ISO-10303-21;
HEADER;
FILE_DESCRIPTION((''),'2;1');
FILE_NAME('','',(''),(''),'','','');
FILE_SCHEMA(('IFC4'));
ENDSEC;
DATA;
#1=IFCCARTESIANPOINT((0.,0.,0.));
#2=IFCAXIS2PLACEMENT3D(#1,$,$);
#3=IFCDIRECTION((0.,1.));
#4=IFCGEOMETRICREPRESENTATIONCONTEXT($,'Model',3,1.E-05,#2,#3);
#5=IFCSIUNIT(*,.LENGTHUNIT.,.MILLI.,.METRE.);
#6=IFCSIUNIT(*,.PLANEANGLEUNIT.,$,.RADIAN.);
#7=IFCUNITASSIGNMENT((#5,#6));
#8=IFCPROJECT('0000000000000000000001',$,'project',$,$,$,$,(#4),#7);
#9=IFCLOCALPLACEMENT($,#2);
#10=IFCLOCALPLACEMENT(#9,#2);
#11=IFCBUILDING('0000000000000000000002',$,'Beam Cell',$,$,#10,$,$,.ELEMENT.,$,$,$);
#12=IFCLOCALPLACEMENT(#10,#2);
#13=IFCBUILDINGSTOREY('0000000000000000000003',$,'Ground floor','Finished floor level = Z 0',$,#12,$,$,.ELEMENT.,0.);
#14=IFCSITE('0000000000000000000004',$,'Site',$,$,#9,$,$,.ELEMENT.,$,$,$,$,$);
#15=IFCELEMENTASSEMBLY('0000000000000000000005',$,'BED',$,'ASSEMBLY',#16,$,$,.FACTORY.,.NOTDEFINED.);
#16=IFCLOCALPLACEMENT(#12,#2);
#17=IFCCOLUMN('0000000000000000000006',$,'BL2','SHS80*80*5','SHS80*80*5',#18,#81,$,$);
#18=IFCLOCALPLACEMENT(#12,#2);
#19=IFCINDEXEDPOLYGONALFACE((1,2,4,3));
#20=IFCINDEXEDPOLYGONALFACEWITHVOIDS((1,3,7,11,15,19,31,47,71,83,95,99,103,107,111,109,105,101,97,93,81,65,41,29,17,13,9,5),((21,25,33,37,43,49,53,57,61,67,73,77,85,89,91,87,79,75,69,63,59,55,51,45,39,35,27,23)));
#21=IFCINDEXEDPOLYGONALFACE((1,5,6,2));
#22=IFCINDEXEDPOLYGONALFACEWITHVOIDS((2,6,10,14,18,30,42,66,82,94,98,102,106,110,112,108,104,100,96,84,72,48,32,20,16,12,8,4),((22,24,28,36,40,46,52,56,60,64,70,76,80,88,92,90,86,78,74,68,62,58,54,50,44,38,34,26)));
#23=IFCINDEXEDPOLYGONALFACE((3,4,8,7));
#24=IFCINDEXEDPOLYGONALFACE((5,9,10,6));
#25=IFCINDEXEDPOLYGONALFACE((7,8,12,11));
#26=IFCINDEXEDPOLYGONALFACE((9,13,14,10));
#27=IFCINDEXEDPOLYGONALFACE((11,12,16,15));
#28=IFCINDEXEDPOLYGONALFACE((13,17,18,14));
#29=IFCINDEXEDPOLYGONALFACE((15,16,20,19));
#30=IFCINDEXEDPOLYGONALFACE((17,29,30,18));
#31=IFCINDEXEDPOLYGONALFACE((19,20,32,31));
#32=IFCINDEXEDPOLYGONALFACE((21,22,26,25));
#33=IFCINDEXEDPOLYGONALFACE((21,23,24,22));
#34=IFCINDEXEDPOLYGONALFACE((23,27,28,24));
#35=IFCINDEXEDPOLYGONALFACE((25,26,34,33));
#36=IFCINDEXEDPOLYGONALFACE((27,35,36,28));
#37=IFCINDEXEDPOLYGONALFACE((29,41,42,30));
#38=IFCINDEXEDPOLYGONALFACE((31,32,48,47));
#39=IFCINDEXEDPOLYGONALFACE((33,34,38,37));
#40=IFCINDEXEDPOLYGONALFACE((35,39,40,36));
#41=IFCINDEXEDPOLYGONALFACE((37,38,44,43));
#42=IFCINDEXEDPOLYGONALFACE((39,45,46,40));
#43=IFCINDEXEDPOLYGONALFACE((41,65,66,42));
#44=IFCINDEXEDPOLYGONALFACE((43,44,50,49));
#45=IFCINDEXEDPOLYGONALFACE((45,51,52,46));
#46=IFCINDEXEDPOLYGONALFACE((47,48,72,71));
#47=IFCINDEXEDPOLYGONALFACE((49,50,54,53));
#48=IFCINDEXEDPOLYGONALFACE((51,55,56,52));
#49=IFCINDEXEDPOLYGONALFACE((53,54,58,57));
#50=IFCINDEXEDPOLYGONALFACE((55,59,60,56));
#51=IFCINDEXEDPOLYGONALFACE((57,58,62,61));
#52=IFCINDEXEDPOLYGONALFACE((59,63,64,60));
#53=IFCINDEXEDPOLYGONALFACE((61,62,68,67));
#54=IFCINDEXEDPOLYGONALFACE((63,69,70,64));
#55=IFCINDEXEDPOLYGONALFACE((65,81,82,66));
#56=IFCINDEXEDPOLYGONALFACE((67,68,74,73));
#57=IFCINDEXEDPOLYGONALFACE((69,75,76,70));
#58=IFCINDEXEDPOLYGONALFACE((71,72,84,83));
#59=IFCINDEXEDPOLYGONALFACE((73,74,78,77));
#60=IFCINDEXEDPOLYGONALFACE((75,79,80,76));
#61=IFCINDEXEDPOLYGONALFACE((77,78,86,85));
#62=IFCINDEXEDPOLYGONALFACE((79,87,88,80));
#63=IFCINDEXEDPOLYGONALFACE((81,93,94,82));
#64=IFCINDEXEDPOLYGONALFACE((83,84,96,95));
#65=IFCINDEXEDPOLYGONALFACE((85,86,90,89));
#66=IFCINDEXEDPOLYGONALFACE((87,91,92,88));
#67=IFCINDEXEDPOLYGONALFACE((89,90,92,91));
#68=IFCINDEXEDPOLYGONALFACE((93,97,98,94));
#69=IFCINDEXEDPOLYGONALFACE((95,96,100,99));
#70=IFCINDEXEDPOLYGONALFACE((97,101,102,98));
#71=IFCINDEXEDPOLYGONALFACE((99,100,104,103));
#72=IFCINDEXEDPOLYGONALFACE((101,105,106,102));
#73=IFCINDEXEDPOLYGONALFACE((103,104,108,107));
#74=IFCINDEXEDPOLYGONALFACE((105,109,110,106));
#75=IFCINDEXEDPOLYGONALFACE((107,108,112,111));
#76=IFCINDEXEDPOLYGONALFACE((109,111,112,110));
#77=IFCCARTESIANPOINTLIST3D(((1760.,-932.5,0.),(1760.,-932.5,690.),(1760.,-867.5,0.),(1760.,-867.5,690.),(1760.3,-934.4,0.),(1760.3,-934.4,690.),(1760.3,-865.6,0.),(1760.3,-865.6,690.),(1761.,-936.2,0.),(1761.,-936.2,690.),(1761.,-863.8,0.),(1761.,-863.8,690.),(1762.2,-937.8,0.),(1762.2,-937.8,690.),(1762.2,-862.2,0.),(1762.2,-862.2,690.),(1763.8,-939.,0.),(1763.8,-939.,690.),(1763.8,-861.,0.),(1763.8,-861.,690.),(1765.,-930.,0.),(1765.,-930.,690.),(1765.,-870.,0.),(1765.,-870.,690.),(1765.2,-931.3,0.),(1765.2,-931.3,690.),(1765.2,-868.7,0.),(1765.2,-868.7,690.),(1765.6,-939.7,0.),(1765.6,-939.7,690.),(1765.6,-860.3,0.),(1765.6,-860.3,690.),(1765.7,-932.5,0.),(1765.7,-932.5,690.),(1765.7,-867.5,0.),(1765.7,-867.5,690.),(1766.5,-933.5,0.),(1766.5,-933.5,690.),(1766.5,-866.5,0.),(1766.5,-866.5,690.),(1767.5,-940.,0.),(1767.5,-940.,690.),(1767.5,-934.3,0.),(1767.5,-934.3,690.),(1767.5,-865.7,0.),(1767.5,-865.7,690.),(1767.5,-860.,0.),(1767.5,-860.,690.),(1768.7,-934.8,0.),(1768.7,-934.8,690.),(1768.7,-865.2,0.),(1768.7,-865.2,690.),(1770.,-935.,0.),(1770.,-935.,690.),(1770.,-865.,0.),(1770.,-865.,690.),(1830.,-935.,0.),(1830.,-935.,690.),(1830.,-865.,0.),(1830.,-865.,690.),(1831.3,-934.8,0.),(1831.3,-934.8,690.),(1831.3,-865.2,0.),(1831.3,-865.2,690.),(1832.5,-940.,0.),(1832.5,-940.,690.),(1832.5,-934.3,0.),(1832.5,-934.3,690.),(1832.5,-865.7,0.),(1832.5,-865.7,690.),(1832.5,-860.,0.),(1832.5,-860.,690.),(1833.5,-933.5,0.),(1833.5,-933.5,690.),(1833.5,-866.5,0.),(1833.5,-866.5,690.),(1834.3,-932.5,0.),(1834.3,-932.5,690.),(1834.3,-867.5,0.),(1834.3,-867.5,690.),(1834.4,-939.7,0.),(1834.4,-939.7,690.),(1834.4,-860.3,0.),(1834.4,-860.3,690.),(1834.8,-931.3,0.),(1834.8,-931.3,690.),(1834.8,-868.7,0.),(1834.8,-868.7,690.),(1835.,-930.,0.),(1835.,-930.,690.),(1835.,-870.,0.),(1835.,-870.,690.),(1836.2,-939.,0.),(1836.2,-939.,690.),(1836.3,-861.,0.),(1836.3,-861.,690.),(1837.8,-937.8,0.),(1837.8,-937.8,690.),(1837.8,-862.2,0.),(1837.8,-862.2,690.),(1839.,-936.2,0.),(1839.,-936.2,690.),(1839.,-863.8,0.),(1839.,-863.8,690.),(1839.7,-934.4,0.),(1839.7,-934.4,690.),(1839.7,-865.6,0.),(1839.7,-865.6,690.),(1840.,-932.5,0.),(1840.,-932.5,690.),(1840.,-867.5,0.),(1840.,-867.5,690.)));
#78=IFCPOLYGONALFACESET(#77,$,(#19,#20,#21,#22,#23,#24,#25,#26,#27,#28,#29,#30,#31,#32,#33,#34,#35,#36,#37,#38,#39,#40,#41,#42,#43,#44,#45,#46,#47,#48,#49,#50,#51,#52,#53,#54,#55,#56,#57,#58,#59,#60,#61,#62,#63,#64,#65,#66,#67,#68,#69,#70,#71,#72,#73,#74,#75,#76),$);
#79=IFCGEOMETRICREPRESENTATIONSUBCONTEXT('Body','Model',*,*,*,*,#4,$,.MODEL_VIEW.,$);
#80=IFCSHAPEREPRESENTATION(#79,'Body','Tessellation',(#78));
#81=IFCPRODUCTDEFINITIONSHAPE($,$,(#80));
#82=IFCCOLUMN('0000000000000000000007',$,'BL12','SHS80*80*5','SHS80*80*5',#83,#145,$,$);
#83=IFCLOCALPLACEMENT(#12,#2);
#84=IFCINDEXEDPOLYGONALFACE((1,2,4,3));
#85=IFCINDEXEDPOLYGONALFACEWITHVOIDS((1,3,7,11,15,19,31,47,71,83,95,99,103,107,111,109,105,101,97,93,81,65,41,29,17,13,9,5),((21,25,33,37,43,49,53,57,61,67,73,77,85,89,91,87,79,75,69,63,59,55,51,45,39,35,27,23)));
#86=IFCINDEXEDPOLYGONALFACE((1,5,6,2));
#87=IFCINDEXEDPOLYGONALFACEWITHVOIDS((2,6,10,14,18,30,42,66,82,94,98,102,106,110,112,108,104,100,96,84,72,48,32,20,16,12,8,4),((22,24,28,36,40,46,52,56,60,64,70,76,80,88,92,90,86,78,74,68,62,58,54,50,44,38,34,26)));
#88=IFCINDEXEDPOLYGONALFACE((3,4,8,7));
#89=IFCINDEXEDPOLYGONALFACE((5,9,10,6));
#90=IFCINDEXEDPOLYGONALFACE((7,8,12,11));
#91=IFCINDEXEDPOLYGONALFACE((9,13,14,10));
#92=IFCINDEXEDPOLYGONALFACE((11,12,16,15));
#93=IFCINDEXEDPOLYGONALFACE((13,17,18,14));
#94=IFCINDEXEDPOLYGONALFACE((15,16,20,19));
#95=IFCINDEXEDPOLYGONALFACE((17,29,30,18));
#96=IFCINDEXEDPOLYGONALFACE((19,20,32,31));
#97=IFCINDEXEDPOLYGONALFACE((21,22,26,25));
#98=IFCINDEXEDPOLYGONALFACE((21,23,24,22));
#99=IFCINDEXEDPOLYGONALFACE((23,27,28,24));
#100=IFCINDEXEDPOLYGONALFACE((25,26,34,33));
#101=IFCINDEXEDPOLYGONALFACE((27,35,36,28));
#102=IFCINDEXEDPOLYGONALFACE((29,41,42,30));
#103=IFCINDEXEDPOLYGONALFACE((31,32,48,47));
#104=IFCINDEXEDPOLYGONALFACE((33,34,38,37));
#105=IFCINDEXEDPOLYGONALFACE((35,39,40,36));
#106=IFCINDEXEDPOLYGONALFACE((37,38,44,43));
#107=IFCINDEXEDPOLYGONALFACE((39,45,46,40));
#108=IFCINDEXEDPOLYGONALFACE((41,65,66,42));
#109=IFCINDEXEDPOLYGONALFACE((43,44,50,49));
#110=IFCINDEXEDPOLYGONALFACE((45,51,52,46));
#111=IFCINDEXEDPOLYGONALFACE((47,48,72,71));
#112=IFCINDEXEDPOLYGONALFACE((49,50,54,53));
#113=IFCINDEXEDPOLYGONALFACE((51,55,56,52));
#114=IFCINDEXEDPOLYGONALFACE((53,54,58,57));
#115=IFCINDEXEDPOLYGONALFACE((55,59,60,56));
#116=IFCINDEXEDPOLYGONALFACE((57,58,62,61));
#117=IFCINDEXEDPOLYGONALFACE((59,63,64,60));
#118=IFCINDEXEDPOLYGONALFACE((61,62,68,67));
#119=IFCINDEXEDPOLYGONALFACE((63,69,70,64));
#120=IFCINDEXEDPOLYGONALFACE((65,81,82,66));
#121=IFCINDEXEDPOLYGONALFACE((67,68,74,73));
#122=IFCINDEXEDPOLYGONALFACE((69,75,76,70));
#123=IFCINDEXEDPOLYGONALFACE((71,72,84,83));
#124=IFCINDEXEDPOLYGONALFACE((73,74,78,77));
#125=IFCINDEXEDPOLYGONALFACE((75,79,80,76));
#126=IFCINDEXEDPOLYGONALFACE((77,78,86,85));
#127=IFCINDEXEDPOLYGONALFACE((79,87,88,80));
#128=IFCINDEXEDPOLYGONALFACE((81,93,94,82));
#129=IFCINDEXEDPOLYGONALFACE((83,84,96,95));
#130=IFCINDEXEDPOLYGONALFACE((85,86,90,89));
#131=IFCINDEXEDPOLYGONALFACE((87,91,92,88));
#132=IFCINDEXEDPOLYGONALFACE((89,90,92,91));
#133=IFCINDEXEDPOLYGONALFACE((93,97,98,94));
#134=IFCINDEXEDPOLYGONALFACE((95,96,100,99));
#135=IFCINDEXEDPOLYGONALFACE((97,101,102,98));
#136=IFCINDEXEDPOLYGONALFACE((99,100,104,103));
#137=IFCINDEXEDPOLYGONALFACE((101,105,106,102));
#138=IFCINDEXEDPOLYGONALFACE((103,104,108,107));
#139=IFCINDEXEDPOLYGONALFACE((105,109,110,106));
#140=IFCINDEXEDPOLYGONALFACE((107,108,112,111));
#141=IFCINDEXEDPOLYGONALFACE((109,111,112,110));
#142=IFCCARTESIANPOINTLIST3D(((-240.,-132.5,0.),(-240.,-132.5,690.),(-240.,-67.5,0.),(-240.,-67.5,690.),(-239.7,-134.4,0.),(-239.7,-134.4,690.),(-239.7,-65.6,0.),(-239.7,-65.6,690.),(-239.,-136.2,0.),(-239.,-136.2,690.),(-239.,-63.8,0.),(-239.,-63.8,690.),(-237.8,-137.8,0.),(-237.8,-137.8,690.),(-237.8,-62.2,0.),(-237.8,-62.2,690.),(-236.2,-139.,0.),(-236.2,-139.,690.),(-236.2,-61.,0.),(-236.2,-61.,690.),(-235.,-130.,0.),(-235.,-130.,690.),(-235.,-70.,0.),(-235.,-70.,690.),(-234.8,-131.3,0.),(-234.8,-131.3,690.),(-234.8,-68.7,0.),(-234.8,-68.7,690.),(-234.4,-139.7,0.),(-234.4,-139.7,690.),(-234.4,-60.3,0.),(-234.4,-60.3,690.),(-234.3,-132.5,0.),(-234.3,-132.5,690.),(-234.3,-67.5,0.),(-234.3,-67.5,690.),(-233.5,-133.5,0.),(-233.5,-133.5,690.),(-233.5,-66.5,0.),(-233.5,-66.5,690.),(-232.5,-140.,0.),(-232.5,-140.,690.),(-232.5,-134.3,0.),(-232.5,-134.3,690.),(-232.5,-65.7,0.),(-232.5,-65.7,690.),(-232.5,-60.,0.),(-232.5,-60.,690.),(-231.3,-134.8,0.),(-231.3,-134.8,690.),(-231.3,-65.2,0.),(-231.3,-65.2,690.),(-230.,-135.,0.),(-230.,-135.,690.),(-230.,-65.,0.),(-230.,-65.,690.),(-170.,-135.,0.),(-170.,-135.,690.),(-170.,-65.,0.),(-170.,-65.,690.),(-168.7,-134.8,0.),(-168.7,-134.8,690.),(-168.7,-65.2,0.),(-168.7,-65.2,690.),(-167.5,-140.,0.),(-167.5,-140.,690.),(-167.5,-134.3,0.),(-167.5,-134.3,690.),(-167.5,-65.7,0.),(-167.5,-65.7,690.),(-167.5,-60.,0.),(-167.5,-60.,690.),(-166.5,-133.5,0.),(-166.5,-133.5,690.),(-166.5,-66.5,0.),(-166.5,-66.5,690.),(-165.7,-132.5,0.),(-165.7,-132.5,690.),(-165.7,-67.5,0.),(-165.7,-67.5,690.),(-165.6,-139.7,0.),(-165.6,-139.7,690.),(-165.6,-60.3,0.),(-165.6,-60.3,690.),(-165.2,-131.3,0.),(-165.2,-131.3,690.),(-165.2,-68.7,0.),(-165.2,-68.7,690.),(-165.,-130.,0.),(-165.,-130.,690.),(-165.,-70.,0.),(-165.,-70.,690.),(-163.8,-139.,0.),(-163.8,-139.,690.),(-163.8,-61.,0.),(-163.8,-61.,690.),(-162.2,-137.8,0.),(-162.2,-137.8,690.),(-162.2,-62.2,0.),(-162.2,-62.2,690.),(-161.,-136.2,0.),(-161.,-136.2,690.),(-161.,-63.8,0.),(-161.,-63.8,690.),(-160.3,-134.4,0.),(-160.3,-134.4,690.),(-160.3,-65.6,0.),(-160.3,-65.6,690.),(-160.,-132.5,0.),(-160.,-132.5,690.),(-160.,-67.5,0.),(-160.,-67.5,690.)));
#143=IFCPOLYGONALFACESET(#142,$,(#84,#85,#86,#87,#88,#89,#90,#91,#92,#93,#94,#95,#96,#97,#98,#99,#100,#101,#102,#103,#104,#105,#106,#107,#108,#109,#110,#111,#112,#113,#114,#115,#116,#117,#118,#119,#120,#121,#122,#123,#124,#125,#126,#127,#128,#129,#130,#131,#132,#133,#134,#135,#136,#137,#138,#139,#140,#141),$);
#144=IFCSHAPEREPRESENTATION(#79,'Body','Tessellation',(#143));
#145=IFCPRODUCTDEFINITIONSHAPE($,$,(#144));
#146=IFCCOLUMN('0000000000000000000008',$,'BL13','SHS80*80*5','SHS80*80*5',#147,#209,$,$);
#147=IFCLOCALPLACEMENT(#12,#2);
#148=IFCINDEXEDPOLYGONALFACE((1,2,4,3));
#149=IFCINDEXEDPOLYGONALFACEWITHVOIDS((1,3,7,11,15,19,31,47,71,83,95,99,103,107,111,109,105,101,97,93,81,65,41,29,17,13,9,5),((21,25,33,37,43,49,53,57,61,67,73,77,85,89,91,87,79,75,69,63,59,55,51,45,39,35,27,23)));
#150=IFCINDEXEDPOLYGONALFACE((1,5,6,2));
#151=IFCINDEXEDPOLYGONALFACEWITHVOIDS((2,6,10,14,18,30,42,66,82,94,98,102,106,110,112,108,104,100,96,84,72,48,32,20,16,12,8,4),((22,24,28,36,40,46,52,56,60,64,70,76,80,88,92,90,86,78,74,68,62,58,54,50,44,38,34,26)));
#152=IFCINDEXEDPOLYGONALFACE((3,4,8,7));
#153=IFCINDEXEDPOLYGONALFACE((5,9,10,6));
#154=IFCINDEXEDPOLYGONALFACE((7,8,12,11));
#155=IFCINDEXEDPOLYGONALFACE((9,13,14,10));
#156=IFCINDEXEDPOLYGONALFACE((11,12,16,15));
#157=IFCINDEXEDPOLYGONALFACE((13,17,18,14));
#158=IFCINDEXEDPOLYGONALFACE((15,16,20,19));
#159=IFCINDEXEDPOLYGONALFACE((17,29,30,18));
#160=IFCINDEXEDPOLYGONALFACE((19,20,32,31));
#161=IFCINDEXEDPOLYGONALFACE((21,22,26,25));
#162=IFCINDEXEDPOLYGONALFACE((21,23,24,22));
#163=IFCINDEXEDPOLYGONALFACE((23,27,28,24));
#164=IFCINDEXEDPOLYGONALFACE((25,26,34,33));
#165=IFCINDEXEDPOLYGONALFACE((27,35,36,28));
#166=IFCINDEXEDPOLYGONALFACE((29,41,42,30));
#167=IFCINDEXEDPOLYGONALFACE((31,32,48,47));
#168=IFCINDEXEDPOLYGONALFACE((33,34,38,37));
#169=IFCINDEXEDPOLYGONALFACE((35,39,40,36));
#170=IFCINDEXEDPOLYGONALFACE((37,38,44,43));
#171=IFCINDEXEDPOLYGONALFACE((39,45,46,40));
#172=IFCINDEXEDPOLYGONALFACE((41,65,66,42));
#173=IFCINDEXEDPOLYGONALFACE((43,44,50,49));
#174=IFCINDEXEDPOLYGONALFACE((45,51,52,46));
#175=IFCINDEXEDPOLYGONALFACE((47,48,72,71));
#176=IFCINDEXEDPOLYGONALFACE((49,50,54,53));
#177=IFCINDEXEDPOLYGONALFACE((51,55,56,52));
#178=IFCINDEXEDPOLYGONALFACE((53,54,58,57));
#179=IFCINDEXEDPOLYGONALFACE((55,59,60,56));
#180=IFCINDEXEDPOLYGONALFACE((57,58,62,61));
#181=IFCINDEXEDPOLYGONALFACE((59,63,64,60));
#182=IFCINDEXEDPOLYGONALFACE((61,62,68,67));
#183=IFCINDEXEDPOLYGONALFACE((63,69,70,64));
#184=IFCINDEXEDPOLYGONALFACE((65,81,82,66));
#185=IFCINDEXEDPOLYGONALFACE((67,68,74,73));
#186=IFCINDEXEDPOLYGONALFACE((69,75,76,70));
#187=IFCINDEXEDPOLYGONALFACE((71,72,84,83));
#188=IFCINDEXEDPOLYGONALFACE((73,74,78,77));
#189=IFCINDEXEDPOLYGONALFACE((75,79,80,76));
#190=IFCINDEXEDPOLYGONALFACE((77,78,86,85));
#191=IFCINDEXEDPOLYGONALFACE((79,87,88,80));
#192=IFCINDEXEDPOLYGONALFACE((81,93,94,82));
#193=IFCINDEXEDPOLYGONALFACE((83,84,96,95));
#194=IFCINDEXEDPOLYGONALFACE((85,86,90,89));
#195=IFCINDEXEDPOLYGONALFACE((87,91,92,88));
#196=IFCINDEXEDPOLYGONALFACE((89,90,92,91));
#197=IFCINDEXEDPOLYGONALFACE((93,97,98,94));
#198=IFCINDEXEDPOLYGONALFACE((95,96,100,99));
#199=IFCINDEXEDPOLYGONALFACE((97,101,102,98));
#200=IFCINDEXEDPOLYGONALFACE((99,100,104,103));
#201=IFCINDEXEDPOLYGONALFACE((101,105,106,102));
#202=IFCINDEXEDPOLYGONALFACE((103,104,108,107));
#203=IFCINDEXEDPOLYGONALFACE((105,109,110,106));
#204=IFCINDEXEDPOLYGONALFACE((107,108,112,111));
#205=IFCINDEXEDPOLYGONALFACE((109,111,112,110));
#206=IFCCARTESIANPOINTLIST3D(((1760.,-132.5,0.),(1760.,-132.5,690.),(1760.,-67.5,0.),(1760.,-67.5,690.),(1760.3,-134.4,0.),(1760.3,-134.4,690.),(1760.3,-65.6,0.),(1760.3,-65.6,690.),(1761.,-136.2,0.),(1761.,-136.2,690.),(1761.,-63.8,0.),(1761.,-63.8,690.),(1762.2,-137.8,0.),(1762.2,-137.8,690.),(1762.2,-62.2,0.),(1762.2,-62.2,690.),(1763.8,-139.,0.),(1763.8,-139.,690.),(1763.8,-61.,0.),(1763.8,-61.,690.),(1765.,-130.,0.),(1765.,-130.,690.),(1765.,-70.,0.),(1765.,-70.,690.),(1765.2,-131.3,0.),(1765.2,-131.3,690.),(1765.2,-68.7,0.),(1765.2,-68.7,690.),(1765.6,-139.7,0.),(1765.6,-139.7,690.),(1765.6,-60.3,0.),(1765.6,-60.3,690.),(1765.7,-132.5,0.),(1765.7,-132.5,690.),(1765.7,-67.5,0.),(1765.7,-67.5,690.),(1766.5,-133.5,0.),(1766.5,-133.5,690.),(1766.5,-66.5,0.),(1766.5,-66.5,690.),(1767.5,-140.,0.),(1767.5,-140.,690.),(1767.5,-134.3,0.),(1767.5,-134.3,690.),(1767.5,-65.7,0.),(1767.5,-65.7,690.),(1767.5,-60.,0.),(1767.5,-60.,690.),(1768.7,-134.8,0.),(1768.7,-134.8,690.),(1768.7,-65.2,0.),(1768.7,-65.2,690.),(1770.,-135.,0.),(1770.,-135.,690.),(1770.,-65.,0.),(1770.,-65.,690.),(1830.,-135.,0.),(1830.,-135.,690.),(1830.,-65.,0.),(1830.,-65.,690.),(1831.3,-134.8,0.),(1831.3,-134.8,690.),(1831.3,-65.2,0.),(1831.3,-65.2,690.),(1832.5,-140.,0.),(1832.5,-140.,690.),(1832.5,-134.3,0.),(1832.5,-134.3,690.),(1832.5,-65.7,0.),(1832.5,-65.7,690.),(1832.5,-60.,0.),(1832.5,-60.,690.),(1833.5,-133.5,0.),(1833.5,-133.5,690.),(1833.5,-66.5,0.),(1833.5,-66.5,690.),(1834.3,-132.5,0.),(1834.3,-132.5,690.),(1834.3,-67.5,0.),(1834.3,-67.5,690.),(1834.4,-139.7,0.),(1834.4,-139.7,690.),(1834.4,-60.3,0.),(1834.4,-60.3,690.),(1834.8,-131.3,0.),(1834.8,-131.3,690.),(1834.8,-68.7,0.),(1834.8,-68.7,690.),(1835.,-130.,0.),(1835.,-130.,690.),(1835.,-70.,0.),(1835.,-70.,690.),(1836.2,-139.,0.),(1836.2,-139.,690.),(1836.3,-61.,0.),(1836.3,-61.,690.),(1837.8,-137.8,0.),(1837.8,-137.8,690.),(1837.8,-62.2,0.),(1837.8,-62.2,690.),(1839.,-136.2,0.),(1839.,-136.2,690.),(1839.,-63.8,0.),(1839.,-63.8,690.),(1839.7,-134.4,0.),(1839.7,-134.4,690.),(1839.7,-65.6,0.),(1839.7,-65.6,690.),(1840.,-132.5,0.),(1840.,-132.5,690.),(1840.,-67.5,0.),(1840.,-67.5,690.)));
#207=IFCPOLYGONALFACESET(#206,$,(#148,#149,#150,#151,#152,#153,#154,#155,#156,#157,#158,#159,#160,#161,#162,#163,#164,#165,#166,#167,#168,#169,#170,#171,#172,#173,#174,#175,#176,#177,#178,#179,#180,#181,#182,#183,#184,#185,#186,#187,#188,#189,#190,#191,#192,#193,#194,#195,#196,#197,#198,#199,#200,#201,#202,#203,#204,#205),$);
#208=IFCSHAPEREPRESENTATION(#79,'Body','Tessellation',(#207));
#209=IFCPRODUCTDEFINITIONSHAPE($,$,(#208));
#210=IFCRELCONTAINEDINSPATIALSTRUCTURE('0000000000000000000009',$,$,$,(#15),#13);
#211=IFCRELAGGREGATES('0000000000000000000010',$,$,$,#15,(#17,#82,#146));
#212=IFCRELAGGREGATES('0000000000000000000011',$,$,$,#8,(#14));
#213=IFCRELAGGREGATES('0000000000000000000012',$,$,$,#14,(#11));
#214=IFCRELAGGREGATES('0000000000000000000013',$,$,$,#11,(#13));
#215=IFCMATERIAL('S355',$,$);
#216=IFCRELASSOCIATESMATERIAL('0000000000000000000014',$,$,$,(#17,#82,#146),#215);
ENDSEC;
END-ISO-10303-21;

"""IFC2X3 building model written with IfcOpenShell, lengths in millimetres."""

from ifc_helpers import new_model, si_unit, direction, frame, origin, origin_2d, place, context, subcontext, project, spatial, hollow_rectangle, extrude, material, element, aggregate, save


model = new_model("IFC2X3")

# Units and contexts
model_context = context("Model", 3, precision=1e-05, world=origin(), true_north=direction((0.0, 1.0)))
body_context = subcontext(model_context, "Body", "Model", "MODEL_VIEW")
ifc_project = project(units=[si_unit("LENGTHUNIT", "METRE", prefix="MILLI"), si_unit("PLANEANGLEUNIT", "RADIAN")], contexts=[model_context])

# Site, building, storey
site_placement = place(None, origin())
site = spatial("IfcSite", under=ifc_project, at=site_placement, Name="Site", CompositionType="ELEMENT")
building_placement = place(site_placement, origin())
building = spatial("IfcBuilding", under=site, at=building_placement, Name="Beam Cell", CompositionType="ELEMENT")
storey_placement = place(building_placement, origin())
storey = spatial("IfcBuildingStorey", under=building, at=storey_placement, Name="Ground floor", Description="Finished floor level = Z 0", CompositionType="ELEMENT", Elevation=0.0)

# Shared definitions
ifc_material = material(Name="S355")

# Element assembly, columns
assembly_1_placement = place(storey_placement, origin())
assembly_1 = element("IfcElementAssembly", 1, at=assembly_1_placement, inside=storey, Name="BED", ObjectType="ASSEMBLY", AssemblyPlace="FACTORY", PredefinedType="NOTDEFINED")
column_1_placement = place(storey_placement, frame((1800.0, -900.0, 0.0), z_axis=(0.0, 0.0, 1.0), x_axis=(1.0, 0.0, 0.0)))
column_1 = element("IfcColumn", 2, at=column_1_placement, material=ifc_material, Name="BL2", Description="SHS80*80*5", ObjectType="SHS80*80*5", context=body_context, shape_type="SweptSolid", body=[
    extrude(hollow_rectangle(XDim=80.0, YDim=80.0, WallThickness=5.0, InnerFilletRadius=5.0, OuterFilletRadius=7.5, at=origin_2d()), origin(), (0.0, 0.0, 1.0), 690.0),
])
column_2_placement = place(storey_placement, frame((-200.0, -100.0, 0.0), z_axis=(0.0, 0.0, 1.0), x_axis=(1.0, 0.0, 0.0)))
column_2 = element("IfcColumn", 3, at=column_2_placement, material=ifc_material, Name="BL12", Description="SHS80*80*5", ObjectType="SHS80*80*5", context=body_context, shape_type="SweptSolid", body=[
    extrude(hollow_rectangle(XDim=80.0, YDim=80.0, WallThickness=5.0, InnerFilletRadius=5.0, OuterFilletRadius=7.5, at=origin_2d()), origin(), (0.0, 0.0, 1.0), 690.0),
])
column_3_placement = place(storey_placement, frame((1800.0, -100.0, 0.0), z_axis=(0.0, 0.0, 1.0), x_axis=(1.0, 0.0, 0.0)))
column_3 = element("IfcColumn", 4, at=column_3_placement, material=ifc_material, Name="BL13", Description="SHS80*80*5", ObjectType="SHS80*80*5", context=body_context, shape_type="SweptSolid", body=[
    extrude(hollow_rectangle(XDim=80.0, YDim=80.0, WallThickness=5.0, InnerFilletRadius=5.0, OuterFilletRadius=7.5, at=origin_2d()), origin(), (0.0, 0.0, 1.0), 690.0),
])

aggregate(assembly_1, [column_1, column_2, column_3])

save(model, "model.ifc")
